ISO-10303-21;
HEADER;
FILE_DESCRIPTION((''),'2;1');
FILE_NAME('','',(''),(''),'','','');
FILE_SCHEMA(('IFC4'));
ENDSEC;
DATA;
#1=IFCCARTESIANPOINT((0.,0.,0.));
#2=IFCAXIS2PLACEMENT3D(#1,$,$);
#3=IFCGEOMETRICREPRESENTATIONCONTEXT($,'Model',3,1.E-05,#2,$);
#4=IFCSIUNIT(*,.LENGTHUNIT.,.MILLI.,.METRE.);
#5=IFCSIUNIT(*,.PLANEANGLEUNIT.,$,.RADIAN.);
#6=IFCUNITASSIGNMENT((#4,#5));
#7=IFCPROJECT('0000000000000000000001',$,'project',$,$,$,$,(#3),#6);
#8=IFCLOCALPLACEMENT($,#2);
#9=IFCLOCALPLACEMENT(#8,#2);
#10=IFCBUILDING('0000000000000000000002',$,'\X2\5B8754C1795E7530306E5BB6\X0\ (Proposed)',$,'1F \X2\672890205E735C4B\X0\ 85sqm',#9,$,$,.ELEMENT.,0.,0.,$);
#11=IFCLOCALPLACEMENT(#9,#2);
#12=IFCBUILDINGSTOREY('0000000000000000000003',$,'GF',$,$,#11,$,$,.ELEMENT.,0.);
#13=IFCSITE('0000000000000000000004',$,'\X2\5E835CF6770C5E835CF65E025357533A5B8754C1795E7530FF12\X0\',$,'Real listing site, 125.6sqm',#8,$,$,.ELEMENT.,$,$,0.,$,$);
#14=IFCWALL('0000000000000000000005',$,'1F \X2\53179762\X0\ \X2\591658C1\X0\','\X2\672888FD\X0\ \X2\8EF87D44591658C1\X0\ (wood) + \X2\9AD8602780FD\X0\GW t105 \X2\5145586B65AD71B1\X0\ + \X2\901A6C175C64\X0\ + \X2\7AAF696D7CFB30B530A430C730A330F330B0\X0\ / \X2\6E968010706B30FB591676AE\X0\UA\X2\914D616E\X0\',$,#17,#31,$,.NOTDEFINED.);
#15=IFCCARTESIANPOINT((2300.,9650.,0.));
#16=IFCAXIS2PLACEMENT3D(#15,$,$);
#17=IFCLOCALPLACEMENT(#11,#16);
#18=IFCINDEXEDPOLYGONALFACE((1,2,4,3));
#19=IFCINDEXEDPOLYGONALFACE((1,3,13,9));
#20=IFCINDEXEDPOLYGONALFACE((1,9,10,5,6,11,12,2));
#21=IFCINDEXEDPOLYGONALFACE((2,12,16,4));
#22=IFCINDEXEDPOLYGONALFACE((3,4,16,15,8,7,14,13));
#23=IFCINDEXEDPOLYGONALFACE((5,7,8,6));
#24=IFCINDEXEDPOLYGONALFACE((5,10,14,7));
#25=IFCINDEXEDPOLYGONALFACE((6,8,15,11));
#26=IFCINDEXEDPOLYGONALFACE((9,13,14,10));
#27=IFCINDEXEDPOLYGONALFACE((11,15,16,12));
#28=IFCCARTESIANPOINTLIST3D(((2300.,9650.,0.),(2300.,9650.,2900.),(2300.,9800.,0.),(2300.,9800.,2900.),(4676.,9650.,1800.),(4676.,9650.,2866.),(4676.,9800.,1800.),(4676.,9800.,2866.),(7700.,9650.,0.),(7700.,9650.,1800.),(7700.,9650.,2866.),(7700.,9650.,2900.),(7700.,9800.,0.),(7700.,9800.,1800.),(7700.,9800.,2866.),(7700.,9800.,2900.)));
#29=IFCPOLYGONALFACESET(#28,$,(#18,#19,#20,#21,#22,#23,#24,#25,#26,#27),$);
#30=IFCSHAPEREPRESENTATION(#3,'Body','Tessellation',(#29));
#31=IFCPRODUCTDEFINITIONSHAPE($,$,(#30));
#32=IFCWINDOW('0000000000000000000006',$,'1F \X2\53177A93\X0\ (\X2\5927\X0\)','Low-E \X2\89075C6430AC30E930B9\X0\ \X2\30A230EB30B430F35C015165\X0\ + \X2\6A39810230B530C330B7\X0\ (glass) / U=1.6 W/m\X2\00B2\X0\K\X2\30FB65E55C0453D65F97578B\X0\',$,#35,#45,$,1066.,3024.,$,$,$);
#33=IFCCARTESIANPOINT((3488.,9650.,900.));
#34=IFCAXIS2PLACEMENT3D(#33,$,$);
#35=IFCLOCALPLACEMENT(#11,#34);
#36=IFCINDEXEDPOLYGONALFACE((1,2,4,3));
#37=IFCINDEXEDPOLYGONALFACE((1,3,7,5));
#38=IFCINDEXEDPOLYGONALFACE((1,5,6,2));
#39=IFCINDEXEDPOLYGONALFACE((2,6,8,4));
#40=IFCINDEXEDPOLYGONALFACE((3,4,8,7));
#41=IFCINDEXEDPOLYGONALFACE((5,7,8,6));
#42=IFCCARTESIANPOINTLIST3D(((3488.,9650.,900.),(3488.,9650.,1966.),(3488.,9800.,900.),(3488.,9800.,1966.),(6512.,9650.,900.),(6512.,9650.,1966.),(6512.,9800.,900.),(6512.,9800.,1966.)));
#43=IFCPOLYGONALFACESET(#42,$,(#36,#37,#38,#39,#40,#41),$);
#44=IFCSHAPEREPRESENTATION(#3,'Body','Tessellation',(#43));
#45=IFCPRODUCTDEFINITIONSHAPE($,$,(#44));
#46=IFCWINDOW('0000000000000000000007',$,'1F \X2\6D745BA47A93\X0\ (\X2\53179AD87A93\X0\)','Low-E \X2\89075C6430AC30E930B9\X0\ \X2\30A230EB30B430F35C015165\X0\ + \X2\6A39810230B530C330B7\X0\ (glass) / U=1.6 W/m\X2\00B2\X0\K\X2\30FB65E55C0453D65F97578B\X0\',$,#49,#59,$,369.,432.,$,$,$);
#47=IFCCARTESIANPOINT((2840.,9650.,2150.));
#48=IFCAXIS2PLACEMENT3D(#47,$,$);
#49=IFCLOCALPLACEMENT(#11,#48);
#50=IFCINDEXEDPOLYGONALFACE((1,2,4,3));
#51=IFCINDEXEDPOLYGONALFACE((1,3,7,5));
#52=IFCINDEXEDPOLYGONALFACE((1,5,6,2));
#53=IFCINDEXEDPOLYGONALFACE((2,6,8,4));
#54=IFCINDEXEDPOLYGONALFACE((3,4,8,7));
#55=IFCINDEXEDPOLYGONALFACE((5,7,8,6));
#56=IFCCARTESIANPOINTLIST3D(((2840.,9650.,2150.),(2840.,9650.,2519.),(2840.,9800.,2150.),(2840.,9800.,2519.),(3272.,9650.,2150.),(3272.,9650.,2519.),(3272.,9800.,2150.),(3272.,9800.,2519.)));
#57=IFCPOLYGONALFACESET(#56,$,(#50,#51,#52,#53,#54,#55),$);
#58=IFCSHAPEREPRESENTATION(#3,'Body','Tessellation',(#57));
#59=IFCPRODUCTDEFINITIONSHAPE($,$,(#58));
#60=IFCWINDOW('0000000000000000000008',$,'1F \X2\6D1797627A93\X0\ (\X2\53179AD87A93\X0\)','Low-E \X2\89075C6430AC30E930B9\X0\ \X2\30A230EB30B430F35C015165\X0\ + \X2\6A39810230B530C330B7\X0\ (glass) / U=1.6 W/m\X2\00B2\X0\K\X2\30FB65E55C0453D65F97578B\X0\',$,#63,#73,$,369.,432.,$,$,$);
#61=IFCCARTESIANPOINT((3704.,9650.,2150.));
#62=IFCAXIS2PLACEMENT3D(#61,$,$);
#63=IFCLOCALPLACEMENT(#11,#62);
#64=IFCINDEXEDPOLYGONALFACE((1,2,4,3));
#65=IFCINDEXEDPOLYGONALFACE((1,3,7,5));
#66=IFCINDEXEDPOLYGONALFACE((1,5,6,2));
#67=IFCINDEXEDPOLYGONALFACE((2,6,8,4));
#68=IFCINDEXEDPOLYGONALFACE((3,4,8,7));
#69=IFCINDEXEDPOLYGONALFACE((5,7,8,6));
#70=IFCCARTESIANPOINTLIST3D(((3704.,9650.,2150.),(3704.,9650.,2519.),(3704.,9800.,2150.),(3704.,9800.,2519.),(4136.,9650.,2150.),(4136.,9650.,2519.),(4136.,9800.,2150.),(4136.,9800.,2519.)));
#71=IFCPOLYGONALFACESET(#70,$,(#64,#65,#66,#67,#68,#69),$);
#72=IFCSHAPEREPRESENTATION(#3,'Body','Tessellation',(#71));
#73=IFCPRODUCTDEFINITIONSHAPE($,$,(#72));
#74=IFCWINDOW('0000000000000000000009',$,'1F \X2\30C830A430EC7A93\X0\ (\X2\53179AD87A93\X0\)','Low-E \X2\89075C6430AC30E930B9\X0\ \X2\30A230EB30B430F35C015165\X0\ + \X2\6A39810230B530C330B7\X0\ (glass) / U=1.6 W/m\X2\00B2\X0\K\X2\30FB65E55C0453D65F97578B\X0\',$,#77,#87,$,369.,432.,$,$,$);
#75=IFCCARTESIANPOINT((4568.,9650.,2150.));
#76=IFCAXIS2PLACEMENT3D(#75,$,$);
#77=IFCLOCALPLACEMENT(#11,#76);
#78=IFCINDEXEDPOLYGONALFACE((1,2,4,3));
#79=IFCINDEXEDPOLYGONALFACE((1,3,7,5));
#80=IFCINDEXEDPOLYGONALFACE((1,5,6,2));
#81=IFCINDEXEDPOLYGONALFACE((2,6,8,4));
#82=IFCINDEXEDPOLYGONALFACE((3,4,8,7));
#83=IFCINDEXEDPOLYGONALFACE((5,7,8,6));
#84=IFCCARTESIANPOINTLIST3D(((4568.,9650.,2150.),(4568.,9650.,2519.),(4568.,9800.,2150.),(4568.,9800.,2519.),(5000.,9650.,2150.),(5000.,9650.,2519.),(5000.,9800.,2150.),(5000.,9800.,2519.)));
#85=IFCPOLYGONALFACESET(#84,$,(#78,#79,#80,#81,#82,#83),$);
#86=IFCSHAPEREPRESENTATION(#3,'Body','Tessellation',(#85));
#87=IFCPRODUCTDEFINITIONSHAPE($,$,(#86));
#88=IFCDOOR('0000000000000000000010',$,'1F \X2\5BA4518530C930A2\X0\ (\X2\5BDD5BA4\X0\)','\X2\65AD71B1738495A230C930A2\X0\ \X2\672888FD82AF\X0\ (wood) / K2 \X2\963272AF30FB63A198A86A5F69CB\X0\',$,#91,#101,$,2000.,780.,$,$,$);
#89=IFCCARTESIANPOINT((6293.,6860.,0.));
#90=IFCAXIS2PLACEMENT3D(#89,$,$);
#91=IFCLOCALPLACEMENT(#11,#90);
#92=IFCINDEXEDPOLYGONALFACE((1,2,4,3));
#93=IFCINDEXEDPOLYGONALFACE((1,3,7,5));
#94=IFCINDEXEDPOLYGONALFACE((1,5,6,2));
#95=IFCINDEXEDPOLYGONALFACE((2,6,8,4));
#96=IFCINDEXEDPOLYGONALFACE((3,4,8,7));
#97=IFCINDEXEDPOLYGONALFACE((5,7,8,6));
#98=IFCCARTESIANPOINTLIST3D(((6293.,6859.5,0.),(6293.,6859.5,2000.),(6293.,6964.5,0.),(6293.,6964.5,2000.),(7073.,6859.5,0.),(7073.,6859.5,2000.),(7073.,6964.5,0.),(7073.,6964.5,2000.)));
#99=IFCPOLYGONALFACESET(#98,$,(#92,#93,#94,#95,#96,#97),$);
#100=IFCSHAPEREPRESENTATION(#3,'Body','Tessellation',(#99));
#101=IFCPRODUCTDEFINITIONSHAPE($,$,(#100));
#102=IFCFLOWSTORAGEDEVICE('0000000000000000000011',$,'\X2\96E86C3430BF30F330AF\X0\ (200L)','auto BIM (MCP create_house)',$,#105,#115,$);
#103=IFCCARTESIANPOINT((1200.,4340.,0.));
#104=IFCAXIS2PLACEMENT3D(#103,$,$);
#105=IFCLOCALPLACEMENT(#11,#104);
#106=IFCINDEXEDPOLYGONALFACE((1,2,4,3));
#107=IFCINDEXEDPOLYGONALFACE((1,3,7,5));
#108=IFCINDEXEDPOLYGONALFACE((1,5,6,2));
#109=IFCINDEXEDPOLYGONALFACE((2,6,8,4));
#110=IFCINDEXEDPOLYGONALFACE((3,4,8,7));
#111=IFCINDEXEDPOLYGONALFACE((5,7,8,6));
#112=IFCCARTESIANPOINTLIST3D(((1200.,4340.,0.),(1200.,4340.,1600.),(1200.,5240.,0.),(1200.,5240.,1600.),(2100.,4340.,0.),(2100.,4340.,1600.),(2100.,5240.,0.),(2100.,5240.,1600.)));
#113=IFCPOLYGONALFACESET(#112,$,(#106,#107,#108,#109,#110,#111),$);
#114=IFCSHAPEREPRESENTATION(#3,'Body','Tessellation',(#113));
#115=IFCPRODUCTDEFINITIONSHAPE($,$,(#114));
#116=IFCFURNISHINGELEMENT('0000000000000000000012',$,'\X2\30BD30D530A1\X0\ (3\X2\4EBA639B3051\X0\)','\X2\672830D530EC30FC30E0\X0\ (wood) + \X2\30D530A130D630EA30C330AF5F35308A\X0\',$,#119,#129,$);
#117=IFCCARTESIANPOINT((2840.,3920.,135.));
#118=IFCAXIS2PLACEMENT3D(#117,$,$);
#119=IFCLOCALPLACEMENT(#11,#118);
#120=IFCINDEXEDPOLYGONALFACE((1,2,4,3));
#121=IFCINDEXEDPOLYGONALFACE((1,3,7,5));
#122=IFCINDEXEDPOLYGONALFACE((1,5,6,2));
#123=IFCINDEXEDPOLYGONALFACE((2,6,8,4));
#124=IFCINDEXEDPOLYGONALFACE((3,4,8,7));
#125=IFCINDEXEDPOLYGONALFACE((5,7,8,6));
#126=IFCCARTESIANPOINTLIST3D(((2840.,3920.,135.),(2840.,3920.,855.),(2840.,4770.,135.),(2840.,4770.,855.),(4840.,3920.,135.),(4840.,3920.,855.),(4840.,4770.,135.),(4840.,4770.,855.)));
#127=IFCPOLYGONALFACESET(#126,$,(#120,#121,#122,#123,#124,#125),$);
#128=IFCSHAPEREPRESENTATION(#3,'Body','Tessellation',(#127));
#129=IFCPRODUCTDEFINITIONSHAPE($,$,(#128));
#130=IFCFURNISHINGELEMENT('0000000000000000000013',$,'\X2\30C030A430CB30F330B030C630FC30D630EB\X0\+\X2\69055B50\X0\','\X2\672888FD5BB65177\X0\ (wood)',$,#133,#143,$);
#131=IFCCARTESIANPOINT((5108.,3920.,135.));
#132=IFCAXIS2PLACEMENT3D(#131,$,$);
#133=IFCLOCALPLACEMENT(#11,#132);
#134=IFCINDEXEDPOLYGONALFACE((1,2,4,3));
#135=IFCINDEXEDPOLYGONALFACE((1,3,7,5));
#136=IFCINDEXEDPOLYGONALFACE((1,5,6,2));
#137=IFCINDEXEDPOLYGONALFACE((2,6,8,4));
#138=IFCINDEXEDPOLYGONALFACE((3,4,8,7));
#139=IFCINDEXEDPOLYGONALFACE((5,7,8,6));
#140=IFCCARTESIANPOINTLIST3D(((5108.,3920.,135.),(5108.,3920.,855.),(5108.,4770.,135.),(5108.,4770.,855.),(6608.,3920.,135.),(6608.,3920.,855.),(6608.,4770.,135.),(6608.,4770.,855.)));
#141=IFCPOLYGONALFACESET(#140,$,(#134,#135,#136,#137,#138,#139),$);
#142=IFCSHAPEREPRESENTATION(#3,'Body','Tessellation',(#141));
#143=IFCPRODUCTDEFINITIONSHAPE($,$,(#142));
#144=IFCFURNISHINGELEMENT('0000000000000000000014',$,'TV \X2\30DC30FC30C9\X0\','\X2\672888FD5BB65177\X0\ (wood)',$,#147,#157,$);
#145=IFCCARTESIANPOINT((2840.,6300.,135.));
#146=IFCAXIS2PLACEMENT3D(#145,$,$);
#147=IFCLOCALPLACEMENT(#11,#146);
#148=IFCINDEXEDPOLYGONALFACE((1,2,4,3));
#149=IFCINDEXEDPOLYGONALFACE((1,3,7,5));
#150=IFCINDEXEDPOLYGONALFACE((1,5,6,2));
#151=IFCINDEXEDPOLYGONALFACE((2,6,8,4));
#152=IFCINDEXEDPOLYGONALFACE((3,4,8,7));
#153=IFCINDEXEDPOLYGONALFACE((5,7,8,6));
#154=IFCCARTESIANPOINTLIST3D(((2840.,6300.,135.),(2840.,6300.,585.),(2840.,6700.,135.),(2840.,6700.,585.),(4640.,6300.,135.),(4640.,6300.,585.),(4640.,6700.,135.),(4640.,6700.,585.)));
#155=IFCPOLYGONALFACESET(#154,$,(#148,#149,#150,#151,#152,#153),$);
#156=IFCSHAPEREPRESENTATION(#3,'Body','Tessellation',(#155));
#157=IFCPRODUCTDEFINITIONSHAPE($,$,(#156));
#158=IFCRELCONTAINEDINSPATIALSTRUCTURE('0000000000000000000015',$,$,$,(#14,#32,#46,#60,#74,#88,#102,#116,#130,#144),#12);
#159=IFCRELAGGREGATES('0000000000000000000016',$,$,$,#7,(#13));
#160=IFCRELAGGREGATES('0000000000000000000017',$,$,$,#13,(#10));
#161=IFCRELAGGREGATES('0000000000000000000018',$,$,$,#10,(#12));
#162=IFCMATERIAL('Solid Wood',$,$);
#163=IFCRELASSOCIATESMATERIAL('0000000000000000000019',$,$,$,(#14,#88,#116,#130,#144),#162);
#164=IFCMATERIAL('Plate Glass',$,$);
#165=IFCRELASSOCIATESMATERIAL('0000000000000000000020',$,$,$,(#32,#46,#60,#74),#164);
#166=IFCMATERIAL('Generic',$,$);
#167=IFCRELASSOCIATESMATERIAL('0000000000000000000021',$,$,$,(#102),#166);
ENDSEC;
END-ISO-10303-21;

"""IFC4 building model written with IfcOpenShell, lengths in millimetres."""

from ifc_helpers import new_model, si_unit, frame, frame_2d, origin, place, context, project, spatial, rectangle, extrude, material, element, fill, save


model = new_model("IFC4")

# Units and contexts
model_context = context("Model", 3, precision=1e-05, world=origin())
ifc_project = project(units=[si_unit("LENGTHUNIT", "METRE", prefix="MILLI"), si_unit("PLANEANGLEUNIT", "RADIAN")], contexts=[model_context])

# Site, building, storey
site_placement = place(None, origin())
site = spatial("IfcSite", under=ifc_project, at=site_placement, Name="広島県広島市南区宇品神田２", ObjectType="Real listing site, 125.6sqm", CompositionType="ELEMENT", RefElevation=0.0)
building_placement = place(site_placement, origin())
building = spatial("IfcBuilding", under=site, at=building_placement, Name="宇品神田の家 (Proposed)", ObjectType="1F 木造平屋 85sqm", CompositionType="ELEMENT", ElevationOfRefHeight=0.0, ElevationOfTerrain=0.0)
storey_placement = place(building_placement, origin())
storey = spatial("IfcBuildingStorey", under=building, at=storey_placement, Name="GF", CompositionType="ELEMENT", Elevation=0.0)

# Wall, openings, windows
ifc_material_1 = material(Name="Solid Wood")
wall_1_placement = place(storey_placement, frame((2300.0, 9650.0, 0.0)))
wall_1 = element("IfcWall", 1, at=wall_1_placement, inside=storey, material=ifc_material_1, Name="1F 北面 外壁", Description="木製 軸組外壁 (wood) + 高性能GW t105 充填断熱 + 通気層 + 窯業系サイディング / 準耐火・外皮UA配慮", PredefinedType="NOTDEFINED", context=model_context, shape_type="SweptSolid", body=[
    extrude(rectangle(XDim=5400.0, YDim=150.0, at=frame_2d((2700.0, 75.0))), frame((2300.0, 9650.0, 0.0)), (0.0, 0.0, 1.0), 2900.0),
])
opening_1_placement = place(storey_placement, frame((3488.0, 9650.0, 900.0)))
opening_1 = element("IfcOpeningElement", 2, at=opening_1_placement, cuts=wall_1, PredefinedType="NOTDEFINED", context=model_context, shape_type="SweptSolid", body=[
    extrude(rectangle(XDim=3024.0, YDim=150.0, at=frame_2d((1512.0, 75.0))), frame((3488.0, 9650.0, 900.0)), (0.0, 0.0, 1.0), 1066.0),
])
opening_2_placement = place(storey_placement, frame((2840.0, 9650.0, 2150.0)))
opening_2 = element("IfcOpeningElement", 3, at=opening_2_placement, cuts=wall_1, PredefinedType="NOTDEFINED", context=model_context, shape_type="SweptSolid", body=[
    extrude(rectangle(XDim=432.0, YDim=150.0, at=frame_2d((216.0, 75.0))), frame((2840.0, 9650.0, 2150.0)), (0.0, 0.0, 1.0), 369.0),
])
opening_3_placement = place(storey_placement, frame((3704.0, 9650.0, 2150.0)))
opening_3 = element("IfcOpeningElement", 4, at=opening_3_placement, cuts=wall_1, PredefinedType="NOTDEFINED", context=model_context, shape_type="SweptSolid", body=[
    extrude(rectangle(XDim=432.0, YDim=150.0, at=frame_2d((216.0, 75.0))), frame((3704.0, 9650.0, 2150.0)), (0.0, 0.0, 1.0), 369.0),
])
opening_4_placement = place(storey_placement, frame((4568.0, 9650.0, 2150.0)))
opening_4 = element("IfcOpeningElement", 5, at=opening_4_placement, cuts=wall_1, PredefinedType="NOTDEFINED", context=model_context, shape_type="SweptSolid", body=[
    extrude(rectangle(XDim=432.0, YDim=150.0, at=frame_2d((216.0, 75.0))), frame((4568.0, 9650.0, 2150.0)), (0.0, 0.0, 1.0), 369.0),
])
ifc_material_2 = material(Name="Plate Glass")
window_1_placement = place(storey_placement, frame((3488.0, 9650.0, 900.0)))
window_1 = element("IfcWindow", 6, at=window_1_placement, inside=storey, material=ifc_material_2, Name="1F 北窓 (大)", Description="Low-E 複層ガラス アルゴン封入 + 樹脂サッシ (glass) / U=1.6 W/m²K・日射取得型", OverallHeight=1066.0, OverallWidth=3024.0, context=model_context, shape_type="SweptSolid", body=[
    extrude(rectangle(XDim=3024.0, YDim=150.0, at=frame_2d((1512.0, 75.0))), frame((3488.0, 9650.0, 900.0)), (0.0, 0.0, 1.0), 1066.0),
])
fill(opening_1, window_1)
window_2_placement = place(storey_placement, frame((2840.0, 9650.0, 2150.0)))
window_2 = element("IfcWindow", 7, at=window_2_placement, inside=storey, material=ifc_material_2, Name="1F 浴室窓 (北高窓)", Description="Low-E 複層ガラス アルゴン封入 + 樹脂サッシ (glass) / U=1.6 W/m²K・日射取得型", OverallHeight=369.0, OverallWidth=432.0, context=model_context, shape_type="SweptSolid", body=[
    extrude(rectangle(XDim=432.0, YDim=150.0, at=frame_2d((216.0, 75.0))), frame((2840.0, 9650.0, 2150.0)), (0.0, 0.0, 1.0), 369.0),
])
fill(opening_2, window_2)
window_3_placement = place(storey_placement, frame((3704.0, 9650.0, 2150.0)))
window_3 = element("IfcWindow", 8, at=window_3_placement, inside=storey, material=ifc_material_2, Name="1F 洗面窓 (北高窓)", Description="Low-E 複層ガラス アルゴン封入 + 樹脂サッシ (glass) / U=1.6 W/m²K・日射取得型", OverallHeight=369.0, OverallWidth=432.0, context=model_context, shape_type="SweptSolid", body=[
    extrude(rectangle(XDim=432.0, YDim=150.0, at=frame_2d((216.0, 75.0))), frame((3704.0, 9650.0, 2150.0)), (0.0, 0.0, 1.0), 369.0),
])
fill(opening_3, window_3)
window_4_placement = place(storey_placement, frame((4568.0, 9650.0, 2150.0)))
window_4 = element("IfcWindow", 9, at=window_4_placement, inside=storey, material=ifc_material_2, Name="1F トイレ窓 (北高窓)", Description="Low-E 複層ガラス アルゴン封入 + 樹脂サッシ (glass) / U=1.6 W/m²K・日射取得型", OverallHeight=369.0, OverallWidth=432.0, context=model_context, shape_type="SweptSolid", body=[
    extrude(rectangle(XDim=432.0, YDim=150.0, at=frame_2d((216.0, 75.0))), frame((4568.0, 9650.0, 2150.0)), (0.0, 0.0, 1.0), 369.0),
])
fill(opening_4, window_4)

# Door
door_1_placement = place(storey_placement, frame((6293.0, 6860.0, 0.0)))
element("IfcDoor", 10, at=door_1_placement, inside=storey, material=ifc_material_1, Name="1F 室内ドア (寝室)", Description="断熱玄関ドア 木製芯 (wood) / K2 防犯・採風機構", OverallHeight=2000.0, OverallWidth=780.0, context=model_context, shape_type="SweptSolid", body=[
    extrude(rectangle(XDim=780.0, YDim=105.0, at=frame_2d((390.0, 52.0))), frame((6293.0, 6860.0, 0.0)), (0.0, 0.0, 1.0), 2000.0),
])

# Flow storage device
ifc_material_3 = material(Name="Generic")
flow_storage_device_placement = place(storey_placement, frame((1200.0, 4340.0, 0.0)))
element("IfcFlowStorageDevice", 11, at=flow_storage_device_placement, inside=storey, material=ifc_material_3, Name="雨水タンク (200L)", Description="auto BIM (MCP create_house)", context=model_context, shape_type="SweptSolid", body=[
    extrude(rectangle(XDim=900.0, YDim=900.0, at=frame_2d((450.0, 450.0))), frame((1200.0, 4340.0, 0.0)), (0.0, 0.0, 1.0), 1600.0),
])

# Furnishing elements
furnishing_1_placement = place(storey_placement, frame((2840.0, 3920.0, 135.0)))
element("IfcFurnishingElement", 12, at=furnishing_1_placement, inside=storey, material=ifc_material_1, Name="ソファ (3人掛け)", Description="木フレーム (wood) + ファブリック張り", context=model_context, shape_type="SweptSolid", body=[
    extrude(rectangle(XDim=2000.0, YDim=850.0, at=frame_2d((1000.0, 425.0))), frame((2840.0, 3920.0, 135.0)), (0.0, 0.0, 1.0), 720.0),
])
furnishing_2_placement = place(storey_placement, frame((5108.0, 3920.0, 135.0)))
element("IfcFurnishingElement", 13, at=furnishing_2_placement, inside=storey, material=ifc_material_1, Name="ダイニングテーブル+椅子", Description="木製家具 (wood)", context=model_context, shape_type="SweptSolid", body=[
    extrude(rectangle(XDim=1500.0, YDim=850.0, at=frame_2d((750.0, 425.0))), frame((5108.0, 3920.0, 135.0)), (0.0, 0.0, 1.0), 720.0),
])
furnishing_3_placement = place(storey_placement, frame((2840.0, 6300.0, 135.0)))
element("IfcFurnishingElement", 14, at=furnishing_3_placement, inside=storey, material=ifc_material_1, Name="TV ボード", Description="木製家具 (wood)", context=model_context, shape_type="SweptSolid", body=[
    extrude(rectangle(XDim=1800.0, YDim=400.0, at=frame_2d((900.0, 200.0))), frame((2840.0, 6300.0, 135.0)), (0.0, 0.0, 1.0), 450.0),
])

save(model, "model.ifc")
